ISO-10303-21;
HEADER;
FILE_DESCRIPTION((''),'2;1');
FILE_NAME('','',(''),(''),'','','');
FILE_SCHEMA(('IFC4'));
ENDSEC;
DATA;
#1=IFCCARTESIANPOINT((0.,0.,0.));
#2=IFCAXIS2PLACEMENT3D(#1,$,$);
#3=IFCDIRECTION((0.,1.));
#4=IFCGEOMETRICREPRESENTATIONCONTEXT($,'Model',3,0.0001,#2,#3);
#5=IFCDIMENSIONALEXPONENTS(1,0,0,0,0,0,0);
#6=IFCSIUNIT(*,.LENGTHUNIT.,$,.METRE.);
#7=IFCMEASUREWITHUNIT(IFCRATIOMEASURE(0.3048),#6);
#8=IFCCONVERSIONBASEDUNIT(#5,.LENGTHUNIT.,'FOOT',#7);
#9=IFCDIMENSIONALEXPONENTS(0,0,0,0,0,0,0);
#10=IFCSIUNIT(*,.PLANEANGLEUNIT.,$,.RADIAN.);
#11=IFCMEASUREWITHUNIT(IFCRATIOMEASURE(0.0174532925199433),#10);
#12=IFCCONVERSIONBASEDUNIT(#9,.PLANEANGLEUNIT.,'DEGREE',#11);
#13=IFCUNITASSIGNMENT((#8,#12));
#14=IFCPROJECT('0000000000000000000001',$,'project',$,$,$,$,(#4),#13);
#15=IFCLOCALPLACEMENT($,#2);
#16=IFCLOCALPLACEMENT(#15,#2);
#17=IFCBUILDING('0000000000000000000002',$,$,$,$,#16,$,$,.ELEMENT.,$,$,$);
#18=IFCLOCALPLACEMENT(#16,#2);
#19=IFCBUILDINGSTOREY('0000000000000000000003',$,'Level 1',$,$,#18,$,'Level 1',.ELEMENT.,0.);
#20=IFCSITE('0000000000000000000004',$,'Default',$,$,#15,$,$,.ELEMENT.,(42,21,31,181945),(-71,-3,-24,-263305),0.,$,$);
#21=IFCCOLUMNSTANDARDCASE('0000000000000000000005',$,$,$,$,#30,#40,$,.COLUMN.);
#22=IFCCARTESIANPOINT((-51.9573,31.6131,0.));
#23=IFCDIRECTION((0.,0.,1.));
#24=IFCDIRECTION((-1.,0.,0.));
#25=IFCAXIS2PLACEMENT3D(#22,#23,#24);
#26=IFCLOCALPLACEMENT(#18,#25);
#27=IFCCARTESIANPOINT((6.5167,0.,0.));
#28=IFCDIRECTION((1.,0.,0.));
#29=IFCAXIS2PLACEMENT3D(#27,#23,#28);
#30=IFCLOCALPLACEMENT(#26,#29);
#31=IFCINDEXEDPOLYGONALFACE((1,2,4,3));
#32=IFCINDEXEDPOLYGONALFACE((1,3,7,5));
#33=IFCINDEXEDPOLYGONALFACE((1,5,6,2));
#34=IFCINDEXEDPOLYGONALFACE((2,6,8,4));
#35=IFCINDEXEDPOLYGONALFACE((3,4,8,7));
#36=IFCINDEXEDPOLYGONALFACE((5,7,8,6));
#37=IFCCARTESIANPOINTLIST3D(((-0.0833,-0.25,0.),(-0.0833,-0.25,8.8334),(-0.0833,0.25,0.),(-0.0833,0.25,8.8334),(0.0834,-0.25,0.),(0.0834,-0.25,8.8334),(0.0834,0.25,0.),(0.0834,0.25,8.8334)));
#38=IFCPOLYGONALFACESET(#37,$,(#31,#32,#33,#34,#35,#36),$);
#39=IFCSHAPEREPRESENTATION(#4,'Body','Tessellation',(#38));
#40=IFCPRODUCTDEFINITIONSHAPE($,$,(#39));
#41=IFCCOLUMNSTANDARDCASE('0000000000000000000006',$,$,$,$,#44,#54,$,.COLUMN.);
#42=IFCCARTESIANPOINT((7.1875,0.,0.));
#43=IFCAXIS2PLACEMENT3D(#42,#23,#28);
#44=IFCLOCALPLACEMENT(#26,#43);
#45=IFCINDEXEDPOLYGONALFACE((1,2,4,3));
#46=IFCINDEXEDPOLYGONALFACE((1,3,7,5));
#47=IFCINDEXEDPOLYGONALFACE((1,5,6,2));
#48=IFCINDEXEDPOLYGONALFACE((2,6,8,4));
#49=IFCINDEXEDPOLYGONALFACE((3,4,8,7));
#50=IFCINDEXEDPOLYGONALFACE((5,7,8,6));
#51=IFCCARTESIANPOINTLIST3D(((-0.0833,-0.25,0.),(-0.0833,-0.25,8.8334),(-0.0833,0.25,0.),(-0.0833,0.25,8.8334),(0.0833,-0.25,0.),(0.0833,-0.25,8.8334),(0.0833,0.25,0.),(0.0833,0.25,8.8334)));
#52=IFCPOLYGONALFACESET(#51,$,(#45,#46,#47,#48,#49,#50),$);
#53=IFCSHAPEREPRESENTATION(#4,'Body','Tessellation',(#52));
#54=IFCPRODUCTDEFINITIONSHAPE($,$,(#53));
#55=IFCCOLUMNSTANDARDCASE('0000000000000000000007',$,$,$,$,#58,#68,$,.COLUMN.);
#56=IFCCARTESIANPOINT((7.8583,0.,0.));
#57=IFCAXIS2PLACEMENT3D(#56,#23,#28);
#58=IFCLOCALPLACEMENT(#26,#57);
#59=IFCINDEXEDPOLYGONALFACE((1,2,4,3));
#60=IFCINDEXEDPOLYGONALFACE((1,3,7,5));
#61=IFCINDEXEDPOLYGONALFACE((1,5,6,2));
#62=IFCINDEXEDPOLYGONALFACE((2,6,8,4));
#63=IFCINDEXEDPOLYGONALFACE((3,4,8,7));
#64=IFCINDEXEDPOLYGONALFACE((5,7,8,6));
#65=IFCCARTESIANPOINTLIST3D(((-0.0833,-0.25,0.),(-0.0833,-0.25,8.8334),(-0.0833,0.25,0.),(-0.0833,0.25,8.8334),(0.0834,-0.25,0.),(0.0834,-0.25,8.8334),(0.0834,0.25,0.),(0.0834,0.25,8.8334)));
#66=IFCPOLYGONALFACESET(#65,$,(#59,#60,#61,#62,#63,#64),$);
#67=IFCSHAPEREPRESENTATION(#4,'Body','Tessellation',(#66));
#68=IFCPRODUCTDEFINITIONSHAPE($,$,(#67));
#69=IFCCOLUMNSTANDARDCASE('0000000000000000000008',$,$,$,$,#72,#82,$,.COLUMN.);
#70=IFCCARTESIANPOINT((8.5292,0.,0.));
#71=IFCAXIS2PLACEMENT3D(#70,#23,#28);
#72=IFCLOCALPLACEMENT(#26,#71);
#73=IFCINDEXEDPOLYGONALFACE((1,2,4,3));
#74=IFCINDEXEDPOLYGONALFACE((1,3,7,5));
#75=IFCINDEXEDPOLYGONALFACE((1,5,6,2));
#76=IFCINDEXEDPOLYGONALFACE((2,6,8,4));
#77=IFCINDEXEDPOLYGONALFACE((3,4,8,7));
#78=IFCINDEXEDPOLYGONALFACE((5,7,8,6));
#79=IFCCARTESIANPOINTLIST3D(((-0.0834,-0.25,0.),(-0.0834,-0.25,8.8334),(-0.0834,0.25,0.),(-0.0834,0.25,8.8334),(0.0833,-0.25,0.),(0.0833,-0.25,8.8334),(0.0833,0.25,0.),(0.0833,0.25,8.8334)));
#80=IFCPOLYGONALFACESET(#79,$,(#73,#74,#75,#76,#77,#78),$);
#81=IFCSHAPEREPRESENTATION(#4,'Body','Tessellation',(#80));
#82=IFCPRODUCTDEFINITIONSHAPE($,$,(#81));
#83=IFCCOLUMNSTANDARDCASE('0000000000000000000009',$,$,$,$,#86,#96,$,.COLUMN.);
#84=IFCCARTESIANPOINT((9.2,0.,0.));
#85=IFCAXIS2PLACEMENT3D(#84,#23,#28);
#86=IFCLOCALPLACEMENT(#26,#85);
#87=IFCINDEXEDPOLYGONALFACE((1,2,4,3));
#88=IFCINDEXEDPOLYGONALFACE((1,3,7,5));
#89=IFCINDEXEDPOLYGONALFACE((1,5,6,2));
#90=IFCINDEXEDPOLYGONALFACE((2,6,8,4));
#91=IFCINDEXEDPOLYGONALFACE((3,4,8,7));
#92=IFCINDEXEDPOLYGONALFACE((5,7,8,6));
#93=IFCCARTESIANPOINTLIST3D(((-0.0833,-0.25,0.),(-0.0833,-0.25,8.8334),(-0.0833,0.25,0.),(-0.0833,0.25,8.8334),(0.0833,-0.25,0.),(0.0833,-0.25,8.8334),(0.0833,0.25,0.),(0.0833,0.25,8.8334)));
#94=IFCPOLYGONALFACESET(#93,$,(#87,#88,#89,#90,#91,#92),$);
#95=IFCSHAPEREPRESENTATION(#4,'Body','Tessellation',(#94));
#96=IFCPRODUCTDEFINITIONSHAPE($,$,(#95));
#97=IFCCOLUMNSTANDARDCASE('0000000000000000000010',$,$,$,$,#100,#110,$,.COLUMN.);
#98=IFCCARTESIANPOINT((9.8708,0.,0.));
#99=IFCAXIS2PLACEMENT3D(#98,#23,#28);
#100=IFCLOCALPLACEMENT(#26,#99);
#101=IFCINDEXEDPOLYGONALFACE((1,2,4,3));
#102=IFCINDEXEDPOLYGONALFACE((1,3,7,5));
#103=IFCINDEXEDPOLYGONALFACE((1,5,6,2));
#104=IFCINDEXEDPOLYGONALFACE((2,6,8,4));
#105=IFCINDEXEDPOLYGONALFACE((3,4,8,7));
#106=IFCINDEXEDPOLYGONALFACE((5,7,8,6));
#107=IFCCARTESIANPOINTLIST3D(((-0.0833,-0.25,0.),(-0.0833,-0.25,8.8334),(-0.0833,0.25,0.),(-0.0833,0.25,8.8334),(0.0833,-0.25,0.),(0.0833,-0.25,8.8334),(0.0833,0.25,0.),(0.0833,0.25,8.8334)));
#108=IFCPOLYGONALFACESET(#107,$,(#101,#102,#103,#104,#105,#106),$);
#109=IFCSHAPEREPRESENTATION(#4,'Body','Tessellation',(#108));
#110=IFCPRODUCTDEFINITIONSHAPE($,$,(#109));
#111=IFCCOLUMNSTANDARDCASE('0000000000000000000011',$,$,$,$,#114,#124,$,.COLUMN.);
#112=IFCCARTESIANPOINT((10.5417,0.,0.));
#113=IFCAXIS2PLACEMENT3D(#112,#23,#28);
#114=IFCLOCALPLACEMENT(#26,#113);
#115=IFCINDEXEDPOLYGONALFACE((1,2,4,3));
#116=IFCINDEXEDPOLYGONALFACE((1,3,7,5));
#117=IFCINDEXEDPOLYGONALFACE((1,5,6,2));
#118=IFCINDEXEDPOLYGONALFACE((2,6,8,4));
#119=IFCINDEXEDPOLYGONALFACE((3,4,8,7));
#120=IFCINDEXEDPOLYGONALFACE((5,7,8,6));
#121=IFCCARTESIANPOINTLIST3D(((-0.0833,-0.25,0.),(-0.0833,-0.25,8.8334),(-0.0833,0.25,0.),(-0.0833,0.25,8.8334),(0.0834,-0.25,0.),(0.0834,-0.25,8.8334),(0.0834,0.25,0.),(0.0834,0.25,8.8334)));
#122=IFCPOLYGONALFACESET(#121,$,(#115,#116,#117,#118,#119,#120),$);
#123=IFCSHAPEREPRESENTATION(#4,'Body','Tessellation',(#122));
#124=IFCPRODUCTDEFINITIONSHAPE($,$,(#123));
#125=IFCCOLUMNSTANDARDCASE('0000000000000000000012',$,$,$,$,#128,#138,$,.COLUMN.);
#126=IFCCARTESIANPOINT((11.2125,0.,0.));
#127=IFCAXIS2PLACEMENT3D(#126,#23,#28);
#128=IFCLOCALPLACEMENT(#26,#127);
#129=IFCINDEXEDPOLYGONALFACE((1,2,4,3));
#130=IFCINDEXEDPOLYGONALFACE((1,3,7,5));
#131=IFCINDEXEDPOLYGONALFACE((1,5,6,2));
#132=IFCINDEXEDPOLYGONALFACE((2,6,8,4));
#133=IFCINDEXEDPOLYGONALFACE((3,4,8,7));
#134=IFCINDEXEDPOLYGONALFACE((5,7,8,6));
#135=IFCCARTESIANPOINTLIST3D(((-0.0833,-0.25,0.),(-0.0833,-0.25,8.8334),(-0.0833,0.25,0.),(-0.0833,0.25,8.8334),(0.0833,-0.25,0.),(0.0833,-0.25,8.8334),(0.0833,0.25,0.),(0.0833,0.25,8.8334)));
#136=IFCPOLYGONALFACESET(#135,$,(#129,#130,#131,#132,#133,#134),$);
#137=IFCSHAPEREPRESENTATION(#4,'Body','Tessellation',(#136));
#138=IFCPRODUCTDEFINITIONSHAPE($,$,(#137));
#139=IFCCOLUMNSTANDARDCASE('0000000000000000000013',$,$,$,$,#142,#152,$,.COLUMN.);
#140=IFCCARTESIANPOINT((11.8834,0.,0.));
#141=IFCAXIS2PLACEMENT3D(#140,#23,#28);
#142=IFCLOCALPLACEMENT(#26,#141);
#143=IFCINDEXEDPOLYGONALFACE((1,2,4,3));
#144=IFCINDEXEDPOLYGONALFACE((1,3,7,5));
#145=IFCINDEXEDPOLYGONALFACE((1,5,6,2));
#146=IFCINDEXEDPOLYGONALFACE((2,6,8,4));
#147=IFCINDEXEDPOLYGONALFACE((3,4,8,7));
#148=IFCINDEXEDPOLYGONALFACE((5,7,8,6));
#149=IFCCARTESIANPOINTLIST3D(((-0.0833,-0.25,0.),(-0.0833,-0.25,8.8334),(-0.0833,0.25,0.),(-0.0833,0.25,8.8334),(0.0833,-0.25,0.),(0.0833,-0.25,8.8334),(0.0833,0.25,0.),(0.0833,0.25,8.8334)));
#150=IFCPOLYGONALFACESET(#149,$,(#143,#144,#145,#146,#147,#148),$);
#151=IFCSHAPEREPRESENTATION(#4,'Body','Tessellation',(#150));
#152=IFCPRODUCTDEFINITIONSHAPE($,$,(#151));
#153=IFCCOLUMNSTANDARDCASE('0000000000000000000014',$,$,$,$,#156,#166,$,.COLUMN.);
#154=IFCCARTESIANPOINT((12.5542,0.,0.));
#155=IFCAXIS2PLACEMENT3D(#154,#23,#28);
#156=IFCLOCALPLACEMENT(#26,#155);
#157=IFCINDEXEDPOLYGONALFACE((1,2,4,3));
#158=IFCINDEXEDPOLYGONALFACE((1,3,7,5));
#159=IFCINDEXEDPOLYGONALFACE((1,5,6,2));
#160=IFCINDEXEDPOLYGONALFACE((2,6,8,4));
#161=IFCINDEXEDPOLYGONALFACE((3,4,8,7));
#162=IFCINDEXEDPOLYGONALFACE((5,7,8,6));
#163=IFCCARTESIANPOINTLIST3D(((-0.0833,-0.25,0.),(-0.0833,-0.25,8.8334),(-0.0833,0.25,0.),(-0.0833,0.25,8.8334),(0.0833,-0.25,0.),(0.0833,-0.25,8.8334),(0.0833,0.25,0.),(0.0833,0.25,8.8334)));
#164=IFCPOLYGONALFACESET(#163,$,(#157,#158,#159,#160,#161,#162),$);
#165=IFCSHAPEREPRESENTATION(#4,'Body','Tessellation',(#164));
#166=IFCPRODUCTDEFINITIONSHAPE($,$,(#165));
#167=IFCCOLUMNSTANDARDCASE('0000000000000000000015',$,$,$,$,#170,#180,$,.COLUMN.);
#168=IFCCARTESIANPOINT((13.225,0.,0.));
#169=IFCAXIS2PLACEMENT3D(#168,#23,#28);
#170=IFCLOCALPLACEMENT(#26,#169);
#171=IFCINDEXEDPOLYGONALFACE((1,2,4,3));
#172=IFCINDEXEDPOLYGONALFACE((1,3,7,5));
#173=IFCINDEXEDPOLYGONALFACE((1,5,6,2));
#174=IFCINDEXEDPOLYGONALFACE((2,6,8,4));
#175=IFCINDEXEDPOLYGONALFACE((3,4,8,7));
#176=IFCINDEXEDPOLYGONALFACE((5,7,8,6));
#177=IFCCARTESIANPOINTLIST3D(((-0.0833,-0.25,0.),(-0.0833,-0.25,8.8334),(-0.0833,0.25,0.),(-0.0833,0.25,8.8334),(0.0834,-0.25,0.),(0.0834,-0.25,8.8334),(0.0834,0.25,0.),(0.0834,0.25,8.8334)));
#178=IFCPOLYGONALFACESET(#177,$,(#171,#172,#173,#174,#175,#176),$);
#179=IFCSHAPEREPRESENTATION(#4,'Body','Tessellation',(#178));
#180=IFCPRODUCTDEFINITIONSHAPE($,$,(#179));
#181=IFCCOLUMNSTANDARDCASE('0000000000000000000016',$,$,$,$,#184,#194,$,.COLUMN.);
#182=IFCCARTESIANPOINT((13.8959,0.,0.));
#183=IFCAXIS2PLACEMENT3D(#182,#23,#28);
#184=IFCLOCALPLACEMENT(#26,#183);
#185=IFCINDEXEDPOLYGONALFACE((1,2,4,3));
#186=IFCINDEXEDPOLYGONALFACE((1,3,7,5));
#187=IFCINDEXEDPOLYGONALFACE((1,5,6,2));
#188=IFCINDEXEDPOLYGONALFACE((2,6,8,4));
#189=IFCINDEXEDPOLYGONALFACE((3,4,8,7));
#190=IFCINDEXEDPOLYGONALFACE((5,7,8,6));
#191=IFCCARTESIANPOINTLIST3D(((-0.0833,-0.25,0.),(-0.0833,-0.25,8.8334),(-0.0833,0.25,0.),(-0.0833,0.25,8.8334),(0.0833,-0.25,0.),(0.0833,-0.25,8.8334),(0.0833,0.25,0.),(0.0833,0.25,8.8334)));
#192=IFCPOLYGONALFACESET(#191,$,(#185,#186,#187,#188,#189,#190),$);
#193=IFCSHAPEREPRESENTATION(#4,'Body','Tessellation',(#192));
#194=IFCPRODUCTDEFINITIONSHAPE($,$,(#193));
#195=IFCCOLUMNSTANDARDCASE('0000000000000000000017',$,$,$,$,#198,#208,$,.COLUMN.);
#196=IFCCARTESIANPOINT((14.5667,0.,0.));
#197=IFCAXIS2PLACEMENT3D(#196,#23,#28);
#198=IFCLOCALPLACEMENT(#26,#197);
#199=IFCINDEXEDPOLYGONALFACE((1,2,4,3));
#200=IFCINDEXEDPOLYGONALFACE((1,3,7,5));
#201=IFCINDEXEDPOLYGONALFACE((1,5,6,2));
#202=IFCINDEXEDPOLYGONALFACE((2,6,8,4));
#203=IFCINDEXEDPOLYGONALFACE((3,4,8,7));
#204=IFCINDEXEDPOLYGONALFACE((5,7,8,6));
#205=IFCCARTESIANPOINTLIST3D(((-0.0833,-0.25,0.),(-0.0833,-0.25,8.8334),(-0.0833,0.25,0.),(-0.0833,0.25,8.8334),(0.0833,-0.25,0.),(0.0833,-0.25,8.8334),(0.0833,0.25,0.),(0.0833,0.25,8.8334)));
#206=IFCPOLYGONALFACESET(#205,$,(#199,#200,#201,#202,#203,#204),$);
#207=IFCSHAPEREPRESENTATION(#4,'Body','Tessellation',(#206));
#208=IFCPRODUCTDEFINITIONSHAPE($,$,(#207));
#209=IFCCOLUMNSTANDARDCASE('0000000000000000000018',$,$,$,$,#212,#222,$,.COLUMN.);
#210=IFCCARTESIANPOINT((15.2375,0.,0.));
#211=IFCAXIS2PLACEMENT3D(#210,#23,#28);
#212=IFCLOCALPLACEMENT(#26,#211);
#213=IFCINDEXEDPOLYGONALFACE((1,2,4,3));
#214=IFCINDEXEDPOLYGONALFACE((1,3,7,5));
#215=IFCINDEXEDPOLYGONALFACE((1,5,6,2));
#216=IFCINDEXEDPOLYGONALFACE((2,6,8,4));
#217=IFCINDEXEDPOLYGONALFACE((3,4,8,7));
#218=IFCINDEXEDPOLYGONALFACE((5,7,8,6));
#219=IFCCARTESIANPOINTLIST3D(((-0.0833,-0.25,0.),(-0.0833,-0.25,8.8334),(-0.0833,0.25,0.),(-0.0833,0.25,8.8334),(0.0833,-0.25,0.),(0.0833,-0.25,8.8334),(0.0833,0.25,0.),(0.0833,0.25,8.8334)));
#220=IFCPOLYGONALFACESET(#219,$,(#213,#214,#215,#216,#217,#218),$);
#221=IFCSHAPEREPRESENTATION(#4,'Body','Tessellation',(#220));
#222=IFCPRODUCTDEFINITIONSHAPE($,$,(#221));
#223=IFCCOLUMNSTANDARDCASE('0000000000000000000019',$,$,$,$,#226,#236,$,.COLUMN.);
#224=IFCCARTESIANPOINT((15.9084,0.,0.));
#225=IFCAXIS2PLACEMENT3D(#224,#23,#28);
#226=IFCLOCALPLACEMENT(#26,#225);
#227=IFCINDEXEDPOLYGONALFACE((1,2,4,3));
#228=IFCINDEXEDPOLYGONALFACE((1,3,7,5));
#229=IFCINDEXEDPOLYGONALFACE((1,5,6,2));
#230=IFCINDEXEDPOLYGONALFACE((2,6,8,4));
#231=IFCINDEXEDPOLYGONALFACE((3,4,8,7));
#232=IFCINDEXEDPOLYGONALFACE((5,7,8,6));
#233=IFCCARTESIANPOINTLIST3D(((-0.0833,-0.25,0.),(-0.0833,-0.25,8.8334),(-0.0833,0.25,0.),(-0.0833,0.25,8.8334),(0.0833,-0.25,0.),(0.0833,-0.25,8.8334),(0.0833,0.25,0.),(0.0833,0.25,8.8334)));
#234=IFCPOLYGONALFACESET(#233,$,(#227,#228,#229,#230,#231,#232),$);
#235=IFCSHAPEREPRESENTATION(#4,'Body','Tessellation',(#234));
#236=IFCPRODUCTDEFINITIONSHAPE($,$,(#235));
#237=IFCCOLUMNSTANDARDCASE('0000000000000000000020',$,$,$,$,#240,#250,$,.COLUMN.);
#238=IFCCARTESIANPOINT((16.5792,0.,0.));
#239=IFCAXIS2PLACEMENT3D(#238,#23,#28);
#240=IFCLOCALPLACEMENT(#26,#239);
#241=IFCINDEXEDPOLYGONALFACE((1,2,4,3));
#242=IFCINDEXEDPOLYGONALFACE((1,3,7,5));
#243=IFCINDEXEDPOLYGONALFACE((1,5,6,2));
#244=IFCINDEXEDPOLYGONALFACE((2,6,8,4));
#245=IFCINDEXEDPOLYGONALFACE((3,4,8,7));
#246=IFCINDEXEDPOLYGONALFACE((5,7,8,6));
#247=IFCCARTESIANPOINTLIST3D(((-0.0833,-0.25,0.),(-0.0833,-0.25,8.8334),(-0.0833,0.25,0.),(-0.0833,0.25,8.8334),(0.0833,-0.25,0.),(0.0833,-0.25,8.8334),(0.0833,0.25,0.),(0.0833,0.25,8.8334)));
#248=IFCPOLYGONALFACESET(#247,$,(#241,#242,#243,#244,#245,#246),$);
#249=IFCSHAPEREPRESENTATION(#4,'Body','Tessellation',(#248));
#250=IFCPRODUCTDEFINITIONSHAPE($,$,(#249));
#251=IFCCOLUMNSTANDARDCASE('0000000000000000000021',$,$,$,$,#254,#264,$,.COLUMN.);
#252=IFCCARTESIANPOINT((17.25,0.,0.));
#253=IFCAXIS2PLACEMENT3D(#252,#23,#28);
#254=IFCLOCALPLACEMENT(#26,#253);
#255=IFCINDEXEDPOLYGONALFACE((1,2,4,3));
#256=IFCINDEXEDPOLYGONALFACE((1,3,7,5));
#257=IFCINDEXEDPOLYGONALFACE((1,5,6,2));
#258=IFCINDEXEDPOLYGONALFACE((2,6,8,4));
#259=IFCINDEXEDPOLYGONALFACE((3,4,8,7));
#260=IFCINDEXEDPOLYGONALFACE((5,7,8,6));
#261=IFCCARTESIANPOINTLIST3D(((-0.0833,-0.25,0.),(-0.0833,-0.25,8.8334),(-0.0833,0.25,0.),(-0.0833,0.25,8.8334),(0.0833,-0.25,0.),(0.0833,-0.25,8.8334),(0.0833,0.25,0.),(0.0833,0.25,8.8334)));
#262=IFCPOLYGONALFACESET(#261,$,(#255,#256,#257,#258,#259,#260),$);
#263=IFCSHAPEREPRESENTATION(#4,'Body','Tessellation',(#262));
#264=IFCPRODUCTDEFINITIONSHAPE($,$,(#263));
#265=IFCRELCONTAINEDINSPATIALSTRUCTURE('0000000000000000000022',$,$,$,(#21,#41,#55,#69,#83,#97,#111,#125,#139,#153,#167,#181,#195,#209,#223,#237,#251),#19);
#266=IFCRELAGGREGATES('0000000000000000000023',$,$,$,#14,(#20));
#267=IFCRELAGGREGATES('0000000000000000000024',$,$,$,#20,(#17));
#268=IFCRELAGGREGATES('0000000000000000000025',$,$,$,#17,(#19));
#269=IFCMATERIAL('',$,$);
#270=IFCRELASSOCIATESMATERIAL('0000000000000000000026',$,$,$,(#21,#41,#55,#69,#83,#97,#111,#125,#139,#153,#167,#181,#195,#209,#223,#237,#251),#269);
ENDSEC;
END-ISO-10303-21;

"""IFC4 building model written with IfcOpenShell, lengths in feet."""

from ifc_helpers import new_model, entity, si_unit, converted_unit, direction, frame, origin, place, context, project, spatial, rectangle, extrude, material, element, save


model = new_model("IFC4")

# Units and contexts
model_context = context("Model", 3, precision=0.0001, world=origin(), true_north=direction((0.0, 1.0)))
ifc_project = project(units=[converted_unit("LENGTHUNIT", "FOOT", entity("IfcRatioMeasure", 0.3048), si_unit("LENGTHUNIT", "METRE"), dimensions=[1, 0, 0, 0, 0, 0, 0]), converted_unit("PLANEANGLEUNIT", "DEGREE", entity("IfcRatioMeasure", 0.0174532925199433), si_unit("PLANEANGLEUNIT", "RADIAN"), dimensions=[0, 0, 0, 0, 0, 0, 0])], contexts=[model_context])

# Site, building, storey
site_placement = place(None, origin())
site = spatial("IfcSite", under=ifc_project, at=site_placement, Name="Default", CompositionType="ELEMENT", RefLatitude=(42, 21, 31, 181945), RefLongitude=(-71, -3, -24, -263305), RefElevation=0.0)
building_placement = place(site_placement, origin())
building = spatial("IfcBuilding", under=site, at=building_placement, CompositionType="ELEMENT")
storey_placement = place(building_placement, origin())
storey = spatial("IfcBuildingStorey", under=building, at=storey_placement, Name="Level 1", LongName="Level 1", CompositionType="ELEMENT", Elevation=0.0)

# Columns
ifc_material_1 = material(Name="")
placement_1 = place(storey_placement, frame((-51.9573, 31.6131, 0.0), z_axis=(0.0, 0.0, 1.0), x_axis=(-1.0, 0.0, 0.0)))
for number, where, z_axis, x_axis in (
    (1, (6.5167, 0.0, 0.0), (0.0, 0.0, 1.0), (1.0, 0.0, 0.0)),
    (2, (7.1875, 0.0, 0.0), (0.0, 0.0, 1.0), (1.0, 0.0, 0.0)),
    (3, (7.8583, 0.0, 0.0), (0.0, 0.0, 1.0), (1.0, 0.0, 0.0)),
    (4, (8.5292, 0.0, 0.0), (0.0, 0.0, 1.0), (1.0, 0.0, 0.0)),
    (5, (9.2, 0.0, 0.0), (0.0, 0.0, 1.0), (1.0, 0.0, 0.0)),
    (6, (9.8708, 0.0, 0.0), (0.0, 0.0, 1.0), (1.0, 0.0, 0.0)),
    (7, (10.5417, 0.0, 0.0), (0.0, 0.0, 1.0), (1.0, 0.0, 0.0)),
    (8, (11.2125, 0.0, 0.0), (0.0, 0.0, 1.0), (1.0, 0.0, 0.0)),
    (9, (11.8834, 0.0, 0.0), (0.0, 0.0, 1.0), (1.0, 0.0, 0.0)),
    (10, (12.5542, 0.0, 0.0), (0.0, 0.0, 1.0), (1.0, 0.0, 0.0)),
    (11, (13.225, 0.0, 0.0), (0.0, 0.0, 1.0), (1.0, 0.0, 0.0)),
    (12, (13.8959, 0.0, 0.0), (0.0, 0.0, 1.0), (1.0, 0.0, 0.0)),
    (13, (14.5667, 0.0, 0.0), (0.0, 0.0, 1.0), (1.0, 0.0, 0.0)),
    (14, (15.2375, 0.0, 0.0), (0.0, 0.0, 1.0), (1.0, 0.0, 0.0)),
    (15, (15.9084, 0.0, 0.0), (0.0, 0.0, 1.0), (1.0, 0.0, 0.0)),
    (16, (16.5792, 0.0, 0.0), (0.0, 0.0, 1.0), (1.0, 0.0, 0.0)),
    (17, (17.25, 0.0, 0.0), (0.0, 0.0, 1.0), (1.0, 0.0, 0.0)),
):
    element("IfcColumnStandardCase", number, at=place(placement_1, frame(where, z_axis=z_axis, x_axis=x_axis)), inside=storey, material=ifc_material_1, PredefinedType="COLUMN", context=model_context, shape_type="SweptSolid", body=[
        extrude(rectangle(XDim=0.1667, YDim=0.5), origin(), (0.0, 0.0, 1.0), 8.8334),
    ])

save(model, "model.ifc")
